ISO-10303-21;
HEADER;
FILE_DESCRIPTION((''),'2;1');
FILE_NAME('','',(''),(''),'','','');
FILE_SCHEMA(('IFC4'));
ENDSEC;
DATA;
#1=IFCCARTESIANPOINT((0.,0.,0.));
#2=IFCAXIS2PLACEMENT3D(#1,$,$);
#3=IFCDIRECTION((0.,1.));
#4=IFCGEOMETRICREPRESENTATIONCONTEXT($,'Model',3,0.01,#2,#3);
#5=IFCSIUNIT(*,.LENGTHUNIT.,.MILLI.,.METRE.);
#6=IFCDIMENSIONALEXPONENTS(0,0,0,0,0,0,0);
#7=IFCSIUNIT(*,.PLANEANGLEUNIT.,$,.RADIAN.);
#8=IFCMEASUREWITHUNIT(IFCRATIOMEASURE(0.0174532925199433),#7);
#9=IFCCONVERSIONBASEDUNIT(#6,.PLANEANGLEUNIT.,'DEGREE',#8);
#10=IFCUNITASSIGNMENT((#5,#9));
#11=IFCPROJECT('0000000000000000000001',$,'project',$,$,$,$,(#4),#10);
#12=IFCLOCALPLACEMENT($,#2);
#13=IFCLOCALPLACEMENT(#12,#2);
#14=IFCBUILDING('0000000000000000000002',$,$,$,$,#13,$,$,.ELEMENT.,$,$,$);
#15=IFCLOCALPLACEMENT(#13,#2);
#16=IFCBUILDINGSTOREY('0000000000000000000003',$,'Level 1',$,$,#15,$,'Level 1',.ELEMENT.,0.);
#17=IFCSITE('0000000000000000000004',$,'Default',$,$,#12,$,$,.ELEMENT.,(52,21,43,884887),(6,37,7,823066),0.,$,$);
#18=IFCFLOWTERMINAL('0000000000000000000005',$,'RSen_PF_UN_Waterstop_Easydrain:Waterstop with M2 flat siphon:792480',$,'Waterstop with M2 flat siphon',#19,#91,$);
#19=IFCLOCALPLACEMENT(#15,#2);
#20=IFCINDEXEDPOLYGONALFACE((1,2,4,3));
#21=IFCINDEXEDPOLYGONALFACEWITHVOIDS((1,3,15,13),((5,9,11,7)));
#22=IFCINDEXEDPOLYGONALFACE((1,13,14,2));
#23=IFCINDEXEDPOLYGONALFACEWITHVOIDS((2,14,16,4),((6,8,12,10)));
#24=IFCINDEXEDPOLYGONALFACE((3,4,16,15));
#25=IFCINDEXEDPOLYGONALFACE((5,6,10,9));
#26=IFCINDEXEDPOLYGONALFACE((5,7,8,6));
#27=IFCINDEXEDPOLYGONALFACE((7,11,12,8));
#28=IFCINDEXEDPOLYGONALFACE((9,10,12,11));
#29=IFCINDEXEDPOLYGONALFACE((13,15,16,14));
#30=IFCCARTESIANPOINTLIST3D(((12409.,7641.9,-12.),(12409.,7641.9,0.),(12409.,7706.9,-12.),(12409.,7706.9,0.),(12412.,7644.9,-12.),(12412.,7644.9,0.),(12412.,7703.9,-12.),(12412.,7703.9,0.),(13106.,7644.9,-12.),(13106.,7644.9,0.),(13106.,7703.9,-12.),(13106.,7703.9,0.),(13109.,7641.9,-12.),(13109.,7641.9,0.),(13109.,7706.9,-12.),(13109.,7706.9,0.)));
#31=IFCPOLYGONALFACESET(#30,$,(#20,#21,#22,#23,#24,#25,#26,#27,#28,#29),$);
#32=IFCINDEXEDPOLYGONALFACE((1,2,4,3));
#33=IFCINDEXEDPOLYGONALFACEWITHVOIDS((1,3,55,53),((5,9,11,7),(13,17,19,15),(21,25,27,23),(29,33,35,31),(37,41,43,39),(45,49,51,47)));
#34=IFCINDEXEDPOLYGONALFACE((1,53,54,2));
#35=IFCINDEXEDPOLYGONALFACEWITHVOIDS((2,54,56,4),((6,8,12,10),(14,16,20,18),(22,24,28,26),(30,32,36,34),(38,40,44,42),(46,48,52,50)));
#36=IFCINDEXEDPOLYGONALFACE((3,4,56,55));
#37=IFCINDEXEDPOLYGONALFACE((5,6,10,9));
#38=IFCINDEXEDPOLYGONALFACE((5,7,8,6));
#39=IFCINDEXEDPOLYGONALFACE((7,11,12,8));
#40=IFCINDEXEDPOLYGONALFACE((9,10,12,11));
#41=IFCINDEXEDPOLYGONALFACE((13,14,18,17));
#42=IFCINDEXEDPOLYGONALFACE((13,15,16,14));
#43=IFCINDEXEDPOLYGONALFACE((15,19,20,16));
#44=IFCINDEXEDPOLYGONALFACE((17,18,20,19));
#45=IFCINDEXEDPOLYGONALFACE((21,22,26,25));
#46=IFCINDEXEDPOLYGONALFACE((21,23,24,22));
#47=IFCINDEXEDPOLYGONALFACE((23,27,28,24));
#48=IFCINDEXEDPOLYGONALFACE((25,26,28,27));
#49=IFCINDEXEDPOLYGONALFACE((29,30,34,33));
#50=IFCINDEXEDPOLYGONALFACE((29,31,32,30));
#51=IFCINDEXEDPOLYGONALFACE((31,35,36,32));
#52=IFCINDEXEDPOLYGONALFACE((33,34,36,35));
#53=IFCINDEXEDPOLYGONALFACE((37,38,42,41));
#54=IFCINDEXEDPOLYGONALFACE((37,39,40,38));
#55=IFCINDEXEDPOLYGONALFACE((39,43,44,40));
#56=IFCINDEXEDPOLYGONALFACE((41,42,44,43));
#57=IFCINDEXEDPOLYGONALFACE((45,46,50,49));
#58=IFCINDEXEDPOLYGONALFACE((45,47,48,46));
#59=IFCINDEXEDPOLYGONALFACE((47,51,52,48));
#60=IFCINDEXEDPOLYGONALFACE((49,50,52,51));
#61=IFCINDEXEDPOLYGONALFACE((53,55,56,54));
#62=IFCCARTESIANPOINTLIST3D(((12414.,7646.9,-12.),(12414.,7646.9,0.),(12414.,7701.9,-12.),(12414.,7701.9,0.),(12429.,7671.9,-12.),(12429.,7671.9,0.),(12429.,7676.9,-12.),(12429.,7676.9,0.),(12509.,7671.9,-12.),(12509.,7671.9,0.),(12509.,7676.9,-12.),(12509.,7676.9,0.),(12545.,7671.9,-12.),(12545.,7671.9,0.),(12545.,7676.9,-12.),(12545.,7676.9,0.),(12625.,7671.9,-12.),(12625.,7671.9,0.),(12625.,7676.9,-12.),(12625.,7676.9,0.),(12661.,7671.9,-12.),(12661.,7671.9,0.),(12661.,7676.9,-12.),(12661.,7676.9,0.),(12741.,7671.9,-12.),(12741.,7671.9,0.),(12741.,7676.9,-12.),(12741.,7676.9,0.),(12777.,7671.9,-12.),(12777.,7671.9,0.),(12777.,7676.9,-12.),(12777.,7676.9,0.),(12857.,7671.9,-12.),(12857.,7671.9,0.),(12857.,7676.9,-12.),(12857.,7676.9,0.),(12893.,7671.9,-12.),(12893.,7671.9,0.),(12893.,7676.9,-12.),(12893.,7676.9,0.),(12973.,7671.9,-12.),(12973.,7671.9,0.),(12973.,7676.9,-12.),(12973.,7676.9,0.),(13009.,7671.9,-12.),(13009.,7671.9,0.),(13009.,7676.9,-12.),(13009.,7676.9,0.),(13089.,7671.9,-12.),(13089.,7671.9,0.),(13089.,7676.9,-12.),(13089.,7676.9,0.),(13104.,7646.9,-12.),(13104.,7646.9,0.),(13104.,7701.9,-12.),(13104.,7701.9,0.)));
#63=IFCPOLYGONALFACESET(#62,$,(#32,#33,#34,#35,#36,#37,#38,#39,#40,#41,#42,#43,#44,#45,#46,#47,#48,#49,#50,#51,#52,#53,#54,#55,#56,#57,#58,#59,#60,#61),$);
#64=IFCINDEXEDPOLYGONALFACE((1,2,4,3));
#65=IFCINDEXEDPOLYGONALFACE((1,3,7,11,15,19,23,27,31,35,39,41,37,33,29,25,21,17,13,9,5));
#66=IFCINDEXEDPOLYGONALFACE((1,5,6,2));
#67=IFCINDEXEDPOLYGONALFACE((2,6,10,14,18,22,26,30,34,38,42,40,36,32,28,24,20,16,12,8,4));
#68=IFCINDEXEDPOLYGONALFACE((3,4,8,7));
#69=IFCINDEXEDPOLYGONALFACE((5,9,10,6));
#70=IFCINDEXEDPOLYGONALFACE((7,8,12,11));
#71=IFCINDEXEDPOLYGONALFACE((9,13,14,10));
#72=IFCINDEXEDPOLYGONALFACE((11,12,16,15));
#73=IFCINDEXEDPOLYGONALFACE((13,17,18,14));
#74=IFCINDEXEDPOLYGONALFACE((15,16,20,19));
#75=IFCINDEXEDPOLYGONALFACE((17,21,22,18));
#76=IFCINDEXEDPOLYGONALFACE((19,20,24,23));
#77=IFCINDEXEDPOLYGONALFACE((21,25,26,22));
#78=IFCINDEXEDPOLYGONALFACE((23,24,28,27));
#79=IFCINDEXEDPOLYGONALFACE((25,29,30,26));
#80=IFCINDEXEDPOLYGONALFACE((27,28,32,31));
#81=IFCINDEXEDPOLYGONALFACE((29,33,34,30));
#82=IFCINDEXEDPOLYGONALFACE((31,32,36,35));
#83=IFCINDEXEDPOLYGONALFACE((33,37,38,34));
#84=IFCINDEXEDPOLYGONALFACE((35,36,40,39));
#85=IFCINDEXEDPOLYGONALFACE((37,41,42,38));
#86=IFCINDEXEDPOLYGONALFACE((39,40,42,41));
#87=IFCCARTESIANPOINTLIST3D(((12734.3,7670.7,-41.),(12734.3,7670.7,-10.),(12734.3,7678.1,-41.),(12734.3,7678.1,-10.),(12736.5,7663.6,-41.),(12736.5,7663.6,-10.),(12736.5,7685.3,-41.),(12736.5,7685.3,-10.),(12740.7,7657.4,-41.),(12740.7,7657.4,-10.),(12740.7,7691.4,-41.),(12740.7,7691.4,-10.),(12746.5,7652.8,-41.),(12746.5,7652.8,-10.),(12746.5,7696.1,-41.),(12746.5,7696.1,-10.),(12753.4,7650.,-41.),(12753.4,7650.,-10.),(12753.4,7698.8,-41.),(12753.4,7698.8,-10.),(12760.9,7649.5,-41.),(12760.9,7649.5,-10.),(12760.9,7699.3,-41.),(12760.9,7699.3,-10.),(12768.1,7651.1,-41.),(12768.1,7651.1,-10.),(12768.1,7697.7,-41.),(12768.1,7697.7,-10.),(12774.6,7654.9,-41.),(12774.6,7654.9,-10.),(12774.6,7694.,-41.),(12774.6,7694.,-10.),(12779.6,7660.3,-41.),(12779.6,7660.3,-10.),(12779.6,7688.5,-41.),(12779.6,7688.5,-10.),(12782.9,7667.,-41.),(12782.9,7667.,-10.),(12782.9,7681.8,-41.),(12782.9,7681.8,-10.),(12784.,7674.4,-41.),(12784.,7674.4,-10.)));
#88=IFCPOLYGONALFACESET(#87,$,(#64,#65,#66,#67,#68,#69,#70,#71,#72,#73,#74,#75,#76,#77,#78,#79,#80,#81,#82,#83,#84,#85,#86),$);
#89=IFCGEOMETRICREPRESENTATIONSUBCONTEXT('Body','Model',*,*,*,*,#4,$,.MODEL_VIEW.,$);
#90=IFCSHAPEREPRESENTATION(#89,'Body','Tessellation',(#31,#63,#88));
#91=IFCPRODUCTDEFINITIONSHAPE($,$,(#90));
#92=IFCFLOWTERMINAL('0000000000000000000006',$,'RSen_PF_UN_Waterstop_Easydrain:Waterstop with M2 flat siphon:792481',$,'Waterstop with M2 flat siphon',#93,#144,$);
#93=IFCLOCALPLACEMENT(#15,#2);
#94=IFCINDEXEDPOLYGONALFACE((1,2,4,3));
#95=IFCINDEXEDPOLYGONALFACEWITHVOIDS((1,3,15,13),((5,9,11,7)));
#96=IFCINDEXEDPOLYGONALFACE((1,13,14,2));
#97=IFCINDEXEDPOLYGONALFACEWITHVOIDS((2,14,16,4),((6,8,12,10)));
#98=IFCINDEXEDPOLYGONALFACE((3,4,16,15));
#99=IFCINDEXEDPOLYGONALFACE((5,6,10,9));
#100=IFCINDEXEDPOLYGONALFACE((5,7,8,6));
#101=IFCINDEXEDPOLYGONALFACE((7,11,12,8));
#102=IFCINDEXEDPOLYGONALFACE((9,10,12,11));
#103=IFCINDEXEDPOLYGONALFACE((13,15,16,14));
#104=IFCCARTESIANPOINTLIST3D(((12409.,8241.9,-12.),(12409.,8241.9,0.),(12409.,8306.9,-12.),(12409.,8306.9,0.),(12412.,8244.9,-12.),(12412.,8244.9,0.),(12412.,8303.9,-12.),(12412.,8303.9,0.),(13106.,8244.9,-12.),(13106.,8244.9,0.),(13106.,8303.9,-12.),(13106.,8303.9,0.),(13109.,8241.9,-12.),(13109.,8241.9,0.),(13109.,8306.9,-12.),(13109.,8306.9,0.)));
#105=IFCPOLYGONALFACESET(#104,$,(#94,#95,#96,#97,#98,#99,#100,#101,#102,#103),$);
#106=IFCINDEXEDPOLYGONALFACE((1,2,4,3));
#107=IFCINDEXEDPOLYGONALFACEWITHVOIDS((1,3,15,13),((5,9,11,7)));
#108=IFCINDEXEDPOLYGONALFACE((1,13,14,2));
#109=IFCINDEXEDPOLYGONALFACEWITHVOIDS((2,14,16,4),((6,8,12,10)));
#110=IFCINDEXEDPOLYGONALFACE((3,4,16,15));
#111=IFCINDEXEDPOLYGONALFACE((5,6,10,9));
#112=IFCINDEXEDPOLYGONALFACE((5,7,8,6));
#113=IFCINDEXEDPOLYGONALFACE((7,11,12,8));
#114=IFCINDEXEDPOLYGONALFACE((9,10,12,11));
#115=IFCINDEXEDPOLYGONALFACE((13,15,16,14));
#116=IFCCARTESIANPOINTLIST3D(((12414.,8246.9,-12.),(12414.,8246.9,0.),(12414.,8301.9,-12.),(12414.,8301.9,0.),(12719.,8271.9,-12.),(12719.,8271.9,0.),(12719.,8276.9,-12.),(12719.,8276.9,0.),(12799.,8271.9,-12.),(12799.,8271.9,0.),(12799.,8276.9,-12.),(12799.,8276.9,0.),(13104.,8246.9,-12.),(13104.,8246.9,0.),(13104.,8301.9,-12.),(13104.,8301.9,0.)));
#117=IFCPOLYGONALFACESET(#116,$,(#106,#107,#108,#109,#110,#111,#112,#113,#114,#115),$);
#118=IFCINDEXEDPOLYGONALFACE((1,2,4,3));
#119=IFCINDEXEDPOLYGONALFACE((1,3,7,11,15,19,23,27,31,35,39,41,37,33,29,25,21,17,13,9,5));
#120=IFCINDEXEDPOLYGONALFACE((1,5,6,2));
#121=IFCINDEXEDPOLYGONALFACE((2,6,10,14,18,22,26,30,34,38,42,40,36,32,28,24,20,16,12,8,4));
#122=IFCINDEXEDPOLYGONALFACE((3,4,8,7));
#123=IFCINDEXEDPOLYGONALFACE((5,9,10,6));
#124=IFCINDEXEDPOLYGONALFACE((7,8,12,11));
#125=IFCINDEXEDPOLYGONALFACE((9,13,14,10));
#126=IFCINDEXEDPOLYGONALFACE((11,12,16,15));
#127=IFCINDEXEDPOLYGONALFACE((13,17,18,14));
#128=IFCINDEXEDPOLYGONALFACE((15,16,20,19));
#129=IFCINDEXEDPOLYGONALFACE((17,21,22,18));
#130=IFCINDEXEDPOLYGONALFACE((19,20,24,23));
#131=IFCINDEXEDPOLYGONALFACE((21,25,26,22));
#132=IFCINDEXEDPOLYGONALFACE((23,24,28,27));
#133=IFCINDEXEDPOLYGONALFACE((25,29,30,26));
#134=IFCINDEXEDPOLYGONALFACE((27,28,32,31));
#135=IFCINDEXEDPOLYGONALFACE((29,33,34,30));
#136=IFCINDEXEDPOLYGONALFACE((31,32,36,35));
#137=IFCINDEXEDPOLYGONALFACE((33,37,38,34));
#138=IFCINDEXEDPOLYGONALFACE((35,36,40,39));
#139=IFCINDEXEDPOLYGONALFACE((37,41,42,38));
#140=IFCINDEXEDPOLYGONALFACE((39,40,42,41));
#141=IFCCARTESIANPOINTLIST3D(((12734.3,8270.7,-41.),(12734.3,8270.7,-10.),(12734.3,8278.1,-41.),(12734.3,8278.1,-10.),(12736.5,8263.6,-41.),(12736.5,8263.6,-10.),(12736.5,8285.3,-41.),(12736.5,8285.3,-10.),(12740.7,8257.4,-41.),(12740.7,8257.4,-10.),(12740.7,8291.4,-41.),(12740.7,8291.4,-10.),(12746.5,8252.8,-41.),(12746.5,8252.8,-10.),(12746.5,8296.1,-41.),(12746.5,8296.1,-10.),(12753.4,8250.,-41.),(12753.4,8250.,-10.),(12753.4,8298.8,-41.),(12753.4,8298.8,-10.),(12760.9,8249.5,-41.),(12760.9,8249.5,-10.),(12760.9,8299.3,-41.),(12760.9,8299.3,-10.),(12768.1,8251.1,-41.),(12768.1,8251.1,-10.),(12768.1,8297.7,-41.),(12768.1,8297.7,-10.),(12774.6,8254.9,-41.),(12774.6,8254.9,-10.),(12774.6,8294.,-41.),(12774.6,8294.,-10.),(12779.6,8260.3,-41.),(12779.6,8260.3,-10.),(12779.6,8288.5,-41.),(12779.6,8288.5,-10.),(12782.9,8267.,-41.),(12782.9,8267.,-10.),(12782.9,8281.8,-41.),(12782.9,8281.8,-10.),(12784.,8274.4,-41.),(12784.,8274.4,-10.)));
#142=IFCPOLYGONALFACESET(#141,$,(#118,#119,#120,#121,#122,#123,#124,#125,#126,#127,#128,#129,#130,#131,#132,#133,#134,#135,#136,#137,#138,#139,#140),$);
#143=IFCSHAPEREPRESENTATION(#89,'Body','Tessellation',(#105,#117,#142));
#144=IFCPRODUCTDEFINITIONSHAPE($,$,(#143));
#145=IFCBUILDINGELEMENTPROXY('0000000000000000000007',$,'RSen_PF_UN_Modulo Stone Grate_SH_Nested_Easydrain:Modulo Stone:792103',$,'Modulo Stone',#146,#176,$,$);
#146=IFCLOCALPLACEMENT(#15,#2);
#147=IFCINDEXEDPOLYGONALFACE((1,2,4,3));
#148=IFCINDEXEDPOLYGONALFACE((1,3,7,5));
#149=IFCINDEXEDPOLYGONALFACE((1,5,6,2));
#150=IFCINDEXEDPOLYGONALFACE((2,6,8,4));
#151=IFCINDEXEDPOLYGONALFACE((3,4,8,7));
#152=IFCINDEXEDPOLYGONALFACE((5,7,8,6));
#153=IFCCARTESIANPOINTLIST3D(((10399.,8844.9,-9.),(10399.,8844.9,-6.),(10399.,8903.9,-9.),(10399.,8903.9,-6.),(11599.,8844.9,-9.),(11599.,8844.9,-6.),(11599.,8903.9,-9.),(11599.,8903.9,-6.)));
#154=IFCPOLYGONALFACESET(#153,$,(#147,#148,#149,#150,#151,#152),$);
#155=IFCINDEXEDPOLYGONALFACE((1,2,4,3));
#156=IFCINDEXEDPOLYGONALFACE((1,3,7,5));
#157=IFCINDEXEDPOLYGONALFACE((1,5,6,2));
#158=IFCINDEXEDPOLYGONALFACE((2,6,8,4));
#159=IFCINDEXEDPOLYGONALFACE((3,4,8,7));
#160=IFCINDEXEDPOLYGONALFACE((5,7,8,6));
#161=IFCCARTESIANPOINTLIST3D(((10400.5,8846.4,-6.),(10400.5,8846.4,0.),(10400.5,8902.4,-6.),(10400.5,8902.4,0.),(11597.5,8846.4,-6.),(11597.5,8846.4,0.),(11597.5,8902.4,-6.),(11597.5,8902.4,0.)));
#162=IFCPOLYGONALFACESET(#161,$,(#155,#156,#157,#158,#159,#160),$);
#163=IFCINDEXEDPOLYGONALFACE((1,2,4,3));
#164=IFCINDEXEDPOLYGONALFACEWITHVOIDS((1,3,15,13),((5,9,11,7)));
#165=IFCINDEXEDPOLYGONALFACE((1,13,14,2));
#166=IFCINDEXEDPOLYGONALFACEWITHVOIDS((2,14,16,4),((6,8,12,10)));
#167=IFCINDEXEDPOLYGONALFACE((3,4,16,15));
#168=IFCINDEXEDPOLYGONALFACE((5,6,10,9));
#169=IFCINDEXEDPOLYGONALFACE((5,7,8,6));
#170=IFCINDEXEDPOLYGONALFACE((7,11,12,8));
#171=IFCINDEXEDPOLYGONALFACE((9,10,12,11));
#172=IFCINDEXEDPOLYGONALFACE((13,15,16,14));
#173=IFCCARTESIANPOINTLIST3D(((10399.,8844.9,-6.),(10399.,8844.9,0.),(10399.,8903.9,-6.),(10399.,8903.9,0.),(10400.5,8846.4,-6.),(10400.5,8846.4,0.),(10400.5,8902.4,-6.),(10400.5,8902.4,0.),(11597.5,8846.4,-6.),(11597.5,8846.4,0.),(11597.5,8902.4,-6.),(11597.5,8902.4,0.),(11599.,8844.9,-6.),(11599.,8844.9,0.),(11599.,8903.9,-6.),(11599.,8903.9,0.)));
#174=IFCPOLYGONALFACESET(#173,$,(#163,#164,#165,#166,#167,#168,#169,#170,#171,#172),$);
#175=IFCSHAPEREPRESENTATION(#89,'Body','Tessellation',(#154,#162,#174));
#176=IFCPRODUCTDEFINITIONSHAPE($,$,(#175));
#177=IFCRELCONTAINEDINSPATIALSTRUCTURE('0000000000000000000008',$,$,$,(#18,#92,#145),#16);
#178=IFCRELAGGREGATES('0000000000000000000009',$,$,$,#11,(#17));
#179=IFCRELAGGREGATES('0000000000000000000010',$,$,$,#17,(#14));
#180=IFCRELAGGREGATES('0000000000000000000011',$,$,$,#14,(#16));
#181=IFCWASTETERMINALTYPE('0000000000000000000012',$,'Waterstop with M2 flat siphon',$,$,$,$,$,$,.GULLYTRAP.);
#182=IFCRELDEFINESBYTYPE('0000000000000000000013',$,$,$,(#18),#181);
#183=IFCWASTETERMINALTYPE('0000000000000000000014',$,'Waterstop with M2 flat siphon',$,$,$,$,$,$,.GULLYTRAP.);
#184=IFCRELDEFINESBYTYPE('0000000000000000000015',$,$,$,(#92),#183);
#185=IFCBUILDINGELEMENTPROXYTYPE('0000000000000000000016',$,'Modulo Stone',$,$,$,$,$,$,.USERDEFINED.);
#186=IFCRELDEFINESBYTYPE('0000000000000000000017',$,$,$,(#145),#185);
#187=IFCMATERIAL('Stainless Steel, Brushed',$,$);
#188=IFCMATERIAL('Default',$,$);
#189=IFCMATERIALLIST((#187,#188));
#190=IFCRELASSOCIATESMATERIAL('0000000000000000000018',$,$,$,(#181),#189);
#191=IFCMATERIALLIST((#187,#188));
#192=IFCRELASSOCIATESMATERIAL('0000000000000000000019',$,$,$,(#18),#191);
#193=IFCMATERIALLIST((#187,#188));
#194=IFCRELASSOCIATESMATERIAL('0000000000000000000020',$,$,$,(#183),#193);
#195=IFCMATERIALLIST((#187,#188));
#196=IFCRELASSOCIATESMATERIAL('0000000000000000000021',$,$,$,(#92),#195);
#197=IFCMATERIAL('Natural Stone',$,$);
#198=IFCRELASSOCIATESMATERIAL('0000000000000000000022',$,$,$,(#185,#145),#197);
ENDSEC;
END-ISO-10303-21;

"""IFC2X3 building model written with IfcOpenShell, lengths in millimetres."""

from ifc_helpers import new_model, entity, si_unit, converted_unit, direction, frame, frame_2d, origin, origin_2d_with_axis, place, context, subcontext, project, spatial, polyline, rectangle, circle, outline, extrude, source, transform, mapped, material, material_list, type_object, type_shapes, element, save


model = new_model("IFC2X3")

# Units and contexts
model_context = context("Model", 3, precision=0.01, world=origin(), true_north=direction((0.0, 1.0)))
body_context = subcontext(model_context, "Body", "Model", "MODEL_VIEW")
ifc_project = project(units=[si_unit("LENGTHUNIT", "METRE", prefix="MILLI"), converted_unit("PLANEANGLEUNIT", "DEGREE", entity("IfcRatioMeasure", 0.0174532925199433), si_unit("PLANEANGLEUNIT", "RADIAN"), dimensions=[0, 0, 0, 0, 0, 0, 0])], contexts=[model_context])

# Site, building, storey
site_placement = place(None, origin())
site = spatial("IfcSite", under=ifc_project, at=site_placement, Name="Default", CompositionType="ELEMENT", RefLatitude=(52, 21, 43, 884887), RefLongitude=(6, 37, 7, 823066), RefElevation=0.0)
building_placement = place(site_placement, origin())
building = spatial("IfcBuilding", under=site, at=building_placement, CompositionType="ELEMENT")
storey_placement = place(building_placement, origin())
storey = spatial("IfcBuildingStorey", under=building, at=storey_placement, Name="Level 1", LongName="Level 1", CompositionType="ELEMENT", Elevation=0.0)

# Flow terminals
ifc_material_1 = material(Name="Stainless Steel, Brushed")
ifc_material_2 = material(Name="Default")
ifc_material_list_1 = material_list([ifc_material_1, ifc_material_2])
ifc_material_list_2 = material_list([ifc_material_1, ifc_material_2])
waste_terminal_type_1 = type_object("IfcWasteTerminalType", Name="Waterstop with M2 flat siphon", PredefinedType="GULLYTRAP", material=ifc_material_list_2)
shared_shape_1 = source(origin(), body_context, "Body", "SweptSolid", [
    extrude(outline(polyline([(-350.0, -32.5), (350.0, -32.5), (350.0, 32.5), (-350.0, 32.5), (-350.0, -32.5)]), holes=[polyline([(-347.0, -29.5), (-347.0, 29.5), (347.0, 29.5), (347.0, -29.5), (-347.0, -29.5)])]), frame((0.0, 0.0, -12.0), z_axis=(0.0, 0.0, 1.0), x_axis=(-1.0, 0.0, 0.0)), (0.0, 0.0, 1.0), 12.0),
    extrude(outline(polyline([(-345.0, -27.5), (345.0, -27.5), (345.0, 27.5), (-345.0, 27.5), (-345.0, -27.5)]), holes=[polyline([(250.0, -2.5), (250.0, 2.5), (330.0, 2.5), (330.0, -2.5), (250.0, -2.5)]), polyline([(-330.0, -2.5), (-330.0, 2.5), (-250.0, 2.5), (-250.0, -2.5), (-330.0, -2.5)]), polyline([(134.0, -2.5), (134.0, 2.5), (214.0, 2.5), (214.0, -2.5), (134.0, -2.5)]), polyline([(18.0, -2.5), (18.0, 2.5), (98.0, 2.5), (98.0, -2.5), (18.0, -2.5)]), polyline([(-98.0, -2.5), (-98.0, 2.5), (-18.0, 2.5), (-18.0, -2.5), (-98.0, -2.5)]), polyline([(-214.0, -2.5), (-214.0, 2.5), (-134.0, 2.5), (-134.0, -2.5), (-214.0, -2.5)])]), frame((0.0, 0.0, -12.0), z_axis=(0.0, 0.0, 1.0), x_axis=(-1.0, 0.0, 0.0)), (0.0, 0.0, 1.0), 12.0),
    extrude(circle(Radius=25.0, at=frame_2d((0.0, 0.0), x_axis=(1.0, 0.0))), frame((0.0, 0.0, -41.0)), (0.0, 0.0, 1.0), 31.0),
])
type_shapes(waste_terminal_type_1, [shared_shape_1])
flow_terminal_1_placement = place(storey_placement, frame((12759.0, 7674.4, 0.0)))
element("IfcFlowTerminal", 1, at=flow_terminal_1_placement, inside=storey, type_object=waste_terminal_type_1, material=ifc_material_list_1, Name="RSen_PF_UN_Waterstop_Easydrain:Waterstop with M2 flat siphon:792480", ObjectType="Waterstop with M2 flat siphon", context=body_context, shape_type="MappedRepresentation", body=[
    mapped(shared_shape_1, transform((0.0, 0.0, 0.0), scale=1.0)),
])
ifc_material_list_3 = material_list([ifc_material_1, ifc_material_2])
ifc_material_list_4 = material_list([ifc_material_1, ifc_material_2])
waste_terminal_type_2 = type_object("IfcWasteTerminalType", Name="Waterstop with M2 flat siphon", PredefinedType="GULLYTRAP", material=ifc_material_list_4)
shared_shape_2 = source(origin(), body_context, "Body", "SweptSolid", [
    extrude(outline(polyline([(-350.0, -32.5), (350.0, -32.5), (350.0, 32.5), (-350.0, 32.5), (-350.0, -32.5)]), holes=[polyline([(-347.0, -29.5), (-347.0, 29.5), (347.0, 29.5), (347.0, -29.5), (-347.0, -29.5)])]), frame((0.0, 0.0, -12.0), z_axis=(0.0, 0.0, 1.0), x_axis=(-1.0, 0.0, 0.0)), (0.0, 0.0, 1.0), 12.0),
    extrude(outline(polyline([(-345.0, -27.5), (345.0, -27.5), (345.0, 27.5), (-345.0, 27.5), (-345.0, -27.5)]), holes=[polyline([(-40.0, -2.5), (-40.0, 2.5), (40.0, 2.5), (40.0, -2.5), (-40.0, -2.5)])]), frame((0.0, 0.0, -12.0), z_axis=(0.0, 0.0, 1.0), x_axis=(-1.0, 0.0, 0.0)), (0.0, 0.0, 1.0), 12.0),
    extrude(circle(Radius=25.0, at=frame_2d((0.0, 0.0), x_axis=(1.0, 0.0))), frame((0.0, 0.0, -41.0)), (0.0, 0.0, 1.0), 31.0),
])
type_shapes(waste_terminal_type_2, [shared_shape_2])
flow_terminal_2_placement = place(storey_placement, frame((12759.0, 8274.4, 0.0)))
element("IfcFlowTerminal", 2, at=flow_terminal_2_placement, inside=storey, type_object=waste_terminal_type_2, material=ifc_material_list_3, Name="RSen_PF_UN_Waterstop_Easydrain:Waterstop with M2 flat siphon:792481", ObjectType="Waterstop with M2 flat siphon", context=body_context, shape_type="MappedRepresentation", body=[
    mapped(shared_shape_2, transform((0.0, 0.0, 0.0), scale=1.0)),
])

# Building element proxy
ifc_material_3 = material(Name="Natural Stone")
building_element_proxy_type = type_object("IfcBuildingElementProxyType", Name="Modulo Stone", PredefinedType="USERDEFINED", material=ifc_material_3)
shared_shape_3 = source(origin(), body_context, "Body", "SweptSolid", [
    extrude(rectangle(XDim=1200.0, YDim=59.0, at=origin_2d_with_axis()), frame((0.0, 0.0, -3.0), z_axis=(0.0, 0.0, 1.0), x_axis=(-1.0, 0.0, 0.0)), (0.0, 0.0, 1.0), 3.0),
    extrude(rectangle(XDim=1197.0, YDim=56.0, at=origin_2d_with_axis()), frame((0.0, 0.0, 0.0), z_axis=(0.0, 0.0, 1.0), x_axis=(-1.0, 0.0, 0.0)), (0.0, 0.0, 1.0), 6.0),
    extrude(outline(polyline([(-600.0, -29.5), (600.0, -29.5), (600.0, 29.5), (-600.0, 29.5), (-600.0, -29.5)]), holes=[polyline([(-598.5, -28.0), (-598.5, 28.0), (598.5, 28.0), (598.5, -28.0), (-598.5, -28.0)])]), frame((0.0, 0.0, 0.0), z_axis=(0.0, 0.0, 1.0), x_axis=(-1.0, 0.0, 0.0)), (0.0, 0.0, 1.0), 6.0),
])
type_shapes(building_element_proxy_type, [shared_shape_3])
proxy_placement = place(storey_placement, frame((10999.0, 8874.4, -6.0)))
element("IfcBuildingElementProxy", 3, at=proxy_placement, inside=storey, type_object=building_element_proxy_type, material=ifc_material_3, Name="RSen_PF_UN_Modulo Stone Grate_SH_Nested_Easydrain:Modulo Stone:792103", ObjectType="Modulo Stone", context=body_context, shape_type="MappedRepresentation", body=[
    mapped(shared_shape_3, transform((0.0, 0.0, 0.0), scale=1.0)),
])

save(model, "model.ifc")
